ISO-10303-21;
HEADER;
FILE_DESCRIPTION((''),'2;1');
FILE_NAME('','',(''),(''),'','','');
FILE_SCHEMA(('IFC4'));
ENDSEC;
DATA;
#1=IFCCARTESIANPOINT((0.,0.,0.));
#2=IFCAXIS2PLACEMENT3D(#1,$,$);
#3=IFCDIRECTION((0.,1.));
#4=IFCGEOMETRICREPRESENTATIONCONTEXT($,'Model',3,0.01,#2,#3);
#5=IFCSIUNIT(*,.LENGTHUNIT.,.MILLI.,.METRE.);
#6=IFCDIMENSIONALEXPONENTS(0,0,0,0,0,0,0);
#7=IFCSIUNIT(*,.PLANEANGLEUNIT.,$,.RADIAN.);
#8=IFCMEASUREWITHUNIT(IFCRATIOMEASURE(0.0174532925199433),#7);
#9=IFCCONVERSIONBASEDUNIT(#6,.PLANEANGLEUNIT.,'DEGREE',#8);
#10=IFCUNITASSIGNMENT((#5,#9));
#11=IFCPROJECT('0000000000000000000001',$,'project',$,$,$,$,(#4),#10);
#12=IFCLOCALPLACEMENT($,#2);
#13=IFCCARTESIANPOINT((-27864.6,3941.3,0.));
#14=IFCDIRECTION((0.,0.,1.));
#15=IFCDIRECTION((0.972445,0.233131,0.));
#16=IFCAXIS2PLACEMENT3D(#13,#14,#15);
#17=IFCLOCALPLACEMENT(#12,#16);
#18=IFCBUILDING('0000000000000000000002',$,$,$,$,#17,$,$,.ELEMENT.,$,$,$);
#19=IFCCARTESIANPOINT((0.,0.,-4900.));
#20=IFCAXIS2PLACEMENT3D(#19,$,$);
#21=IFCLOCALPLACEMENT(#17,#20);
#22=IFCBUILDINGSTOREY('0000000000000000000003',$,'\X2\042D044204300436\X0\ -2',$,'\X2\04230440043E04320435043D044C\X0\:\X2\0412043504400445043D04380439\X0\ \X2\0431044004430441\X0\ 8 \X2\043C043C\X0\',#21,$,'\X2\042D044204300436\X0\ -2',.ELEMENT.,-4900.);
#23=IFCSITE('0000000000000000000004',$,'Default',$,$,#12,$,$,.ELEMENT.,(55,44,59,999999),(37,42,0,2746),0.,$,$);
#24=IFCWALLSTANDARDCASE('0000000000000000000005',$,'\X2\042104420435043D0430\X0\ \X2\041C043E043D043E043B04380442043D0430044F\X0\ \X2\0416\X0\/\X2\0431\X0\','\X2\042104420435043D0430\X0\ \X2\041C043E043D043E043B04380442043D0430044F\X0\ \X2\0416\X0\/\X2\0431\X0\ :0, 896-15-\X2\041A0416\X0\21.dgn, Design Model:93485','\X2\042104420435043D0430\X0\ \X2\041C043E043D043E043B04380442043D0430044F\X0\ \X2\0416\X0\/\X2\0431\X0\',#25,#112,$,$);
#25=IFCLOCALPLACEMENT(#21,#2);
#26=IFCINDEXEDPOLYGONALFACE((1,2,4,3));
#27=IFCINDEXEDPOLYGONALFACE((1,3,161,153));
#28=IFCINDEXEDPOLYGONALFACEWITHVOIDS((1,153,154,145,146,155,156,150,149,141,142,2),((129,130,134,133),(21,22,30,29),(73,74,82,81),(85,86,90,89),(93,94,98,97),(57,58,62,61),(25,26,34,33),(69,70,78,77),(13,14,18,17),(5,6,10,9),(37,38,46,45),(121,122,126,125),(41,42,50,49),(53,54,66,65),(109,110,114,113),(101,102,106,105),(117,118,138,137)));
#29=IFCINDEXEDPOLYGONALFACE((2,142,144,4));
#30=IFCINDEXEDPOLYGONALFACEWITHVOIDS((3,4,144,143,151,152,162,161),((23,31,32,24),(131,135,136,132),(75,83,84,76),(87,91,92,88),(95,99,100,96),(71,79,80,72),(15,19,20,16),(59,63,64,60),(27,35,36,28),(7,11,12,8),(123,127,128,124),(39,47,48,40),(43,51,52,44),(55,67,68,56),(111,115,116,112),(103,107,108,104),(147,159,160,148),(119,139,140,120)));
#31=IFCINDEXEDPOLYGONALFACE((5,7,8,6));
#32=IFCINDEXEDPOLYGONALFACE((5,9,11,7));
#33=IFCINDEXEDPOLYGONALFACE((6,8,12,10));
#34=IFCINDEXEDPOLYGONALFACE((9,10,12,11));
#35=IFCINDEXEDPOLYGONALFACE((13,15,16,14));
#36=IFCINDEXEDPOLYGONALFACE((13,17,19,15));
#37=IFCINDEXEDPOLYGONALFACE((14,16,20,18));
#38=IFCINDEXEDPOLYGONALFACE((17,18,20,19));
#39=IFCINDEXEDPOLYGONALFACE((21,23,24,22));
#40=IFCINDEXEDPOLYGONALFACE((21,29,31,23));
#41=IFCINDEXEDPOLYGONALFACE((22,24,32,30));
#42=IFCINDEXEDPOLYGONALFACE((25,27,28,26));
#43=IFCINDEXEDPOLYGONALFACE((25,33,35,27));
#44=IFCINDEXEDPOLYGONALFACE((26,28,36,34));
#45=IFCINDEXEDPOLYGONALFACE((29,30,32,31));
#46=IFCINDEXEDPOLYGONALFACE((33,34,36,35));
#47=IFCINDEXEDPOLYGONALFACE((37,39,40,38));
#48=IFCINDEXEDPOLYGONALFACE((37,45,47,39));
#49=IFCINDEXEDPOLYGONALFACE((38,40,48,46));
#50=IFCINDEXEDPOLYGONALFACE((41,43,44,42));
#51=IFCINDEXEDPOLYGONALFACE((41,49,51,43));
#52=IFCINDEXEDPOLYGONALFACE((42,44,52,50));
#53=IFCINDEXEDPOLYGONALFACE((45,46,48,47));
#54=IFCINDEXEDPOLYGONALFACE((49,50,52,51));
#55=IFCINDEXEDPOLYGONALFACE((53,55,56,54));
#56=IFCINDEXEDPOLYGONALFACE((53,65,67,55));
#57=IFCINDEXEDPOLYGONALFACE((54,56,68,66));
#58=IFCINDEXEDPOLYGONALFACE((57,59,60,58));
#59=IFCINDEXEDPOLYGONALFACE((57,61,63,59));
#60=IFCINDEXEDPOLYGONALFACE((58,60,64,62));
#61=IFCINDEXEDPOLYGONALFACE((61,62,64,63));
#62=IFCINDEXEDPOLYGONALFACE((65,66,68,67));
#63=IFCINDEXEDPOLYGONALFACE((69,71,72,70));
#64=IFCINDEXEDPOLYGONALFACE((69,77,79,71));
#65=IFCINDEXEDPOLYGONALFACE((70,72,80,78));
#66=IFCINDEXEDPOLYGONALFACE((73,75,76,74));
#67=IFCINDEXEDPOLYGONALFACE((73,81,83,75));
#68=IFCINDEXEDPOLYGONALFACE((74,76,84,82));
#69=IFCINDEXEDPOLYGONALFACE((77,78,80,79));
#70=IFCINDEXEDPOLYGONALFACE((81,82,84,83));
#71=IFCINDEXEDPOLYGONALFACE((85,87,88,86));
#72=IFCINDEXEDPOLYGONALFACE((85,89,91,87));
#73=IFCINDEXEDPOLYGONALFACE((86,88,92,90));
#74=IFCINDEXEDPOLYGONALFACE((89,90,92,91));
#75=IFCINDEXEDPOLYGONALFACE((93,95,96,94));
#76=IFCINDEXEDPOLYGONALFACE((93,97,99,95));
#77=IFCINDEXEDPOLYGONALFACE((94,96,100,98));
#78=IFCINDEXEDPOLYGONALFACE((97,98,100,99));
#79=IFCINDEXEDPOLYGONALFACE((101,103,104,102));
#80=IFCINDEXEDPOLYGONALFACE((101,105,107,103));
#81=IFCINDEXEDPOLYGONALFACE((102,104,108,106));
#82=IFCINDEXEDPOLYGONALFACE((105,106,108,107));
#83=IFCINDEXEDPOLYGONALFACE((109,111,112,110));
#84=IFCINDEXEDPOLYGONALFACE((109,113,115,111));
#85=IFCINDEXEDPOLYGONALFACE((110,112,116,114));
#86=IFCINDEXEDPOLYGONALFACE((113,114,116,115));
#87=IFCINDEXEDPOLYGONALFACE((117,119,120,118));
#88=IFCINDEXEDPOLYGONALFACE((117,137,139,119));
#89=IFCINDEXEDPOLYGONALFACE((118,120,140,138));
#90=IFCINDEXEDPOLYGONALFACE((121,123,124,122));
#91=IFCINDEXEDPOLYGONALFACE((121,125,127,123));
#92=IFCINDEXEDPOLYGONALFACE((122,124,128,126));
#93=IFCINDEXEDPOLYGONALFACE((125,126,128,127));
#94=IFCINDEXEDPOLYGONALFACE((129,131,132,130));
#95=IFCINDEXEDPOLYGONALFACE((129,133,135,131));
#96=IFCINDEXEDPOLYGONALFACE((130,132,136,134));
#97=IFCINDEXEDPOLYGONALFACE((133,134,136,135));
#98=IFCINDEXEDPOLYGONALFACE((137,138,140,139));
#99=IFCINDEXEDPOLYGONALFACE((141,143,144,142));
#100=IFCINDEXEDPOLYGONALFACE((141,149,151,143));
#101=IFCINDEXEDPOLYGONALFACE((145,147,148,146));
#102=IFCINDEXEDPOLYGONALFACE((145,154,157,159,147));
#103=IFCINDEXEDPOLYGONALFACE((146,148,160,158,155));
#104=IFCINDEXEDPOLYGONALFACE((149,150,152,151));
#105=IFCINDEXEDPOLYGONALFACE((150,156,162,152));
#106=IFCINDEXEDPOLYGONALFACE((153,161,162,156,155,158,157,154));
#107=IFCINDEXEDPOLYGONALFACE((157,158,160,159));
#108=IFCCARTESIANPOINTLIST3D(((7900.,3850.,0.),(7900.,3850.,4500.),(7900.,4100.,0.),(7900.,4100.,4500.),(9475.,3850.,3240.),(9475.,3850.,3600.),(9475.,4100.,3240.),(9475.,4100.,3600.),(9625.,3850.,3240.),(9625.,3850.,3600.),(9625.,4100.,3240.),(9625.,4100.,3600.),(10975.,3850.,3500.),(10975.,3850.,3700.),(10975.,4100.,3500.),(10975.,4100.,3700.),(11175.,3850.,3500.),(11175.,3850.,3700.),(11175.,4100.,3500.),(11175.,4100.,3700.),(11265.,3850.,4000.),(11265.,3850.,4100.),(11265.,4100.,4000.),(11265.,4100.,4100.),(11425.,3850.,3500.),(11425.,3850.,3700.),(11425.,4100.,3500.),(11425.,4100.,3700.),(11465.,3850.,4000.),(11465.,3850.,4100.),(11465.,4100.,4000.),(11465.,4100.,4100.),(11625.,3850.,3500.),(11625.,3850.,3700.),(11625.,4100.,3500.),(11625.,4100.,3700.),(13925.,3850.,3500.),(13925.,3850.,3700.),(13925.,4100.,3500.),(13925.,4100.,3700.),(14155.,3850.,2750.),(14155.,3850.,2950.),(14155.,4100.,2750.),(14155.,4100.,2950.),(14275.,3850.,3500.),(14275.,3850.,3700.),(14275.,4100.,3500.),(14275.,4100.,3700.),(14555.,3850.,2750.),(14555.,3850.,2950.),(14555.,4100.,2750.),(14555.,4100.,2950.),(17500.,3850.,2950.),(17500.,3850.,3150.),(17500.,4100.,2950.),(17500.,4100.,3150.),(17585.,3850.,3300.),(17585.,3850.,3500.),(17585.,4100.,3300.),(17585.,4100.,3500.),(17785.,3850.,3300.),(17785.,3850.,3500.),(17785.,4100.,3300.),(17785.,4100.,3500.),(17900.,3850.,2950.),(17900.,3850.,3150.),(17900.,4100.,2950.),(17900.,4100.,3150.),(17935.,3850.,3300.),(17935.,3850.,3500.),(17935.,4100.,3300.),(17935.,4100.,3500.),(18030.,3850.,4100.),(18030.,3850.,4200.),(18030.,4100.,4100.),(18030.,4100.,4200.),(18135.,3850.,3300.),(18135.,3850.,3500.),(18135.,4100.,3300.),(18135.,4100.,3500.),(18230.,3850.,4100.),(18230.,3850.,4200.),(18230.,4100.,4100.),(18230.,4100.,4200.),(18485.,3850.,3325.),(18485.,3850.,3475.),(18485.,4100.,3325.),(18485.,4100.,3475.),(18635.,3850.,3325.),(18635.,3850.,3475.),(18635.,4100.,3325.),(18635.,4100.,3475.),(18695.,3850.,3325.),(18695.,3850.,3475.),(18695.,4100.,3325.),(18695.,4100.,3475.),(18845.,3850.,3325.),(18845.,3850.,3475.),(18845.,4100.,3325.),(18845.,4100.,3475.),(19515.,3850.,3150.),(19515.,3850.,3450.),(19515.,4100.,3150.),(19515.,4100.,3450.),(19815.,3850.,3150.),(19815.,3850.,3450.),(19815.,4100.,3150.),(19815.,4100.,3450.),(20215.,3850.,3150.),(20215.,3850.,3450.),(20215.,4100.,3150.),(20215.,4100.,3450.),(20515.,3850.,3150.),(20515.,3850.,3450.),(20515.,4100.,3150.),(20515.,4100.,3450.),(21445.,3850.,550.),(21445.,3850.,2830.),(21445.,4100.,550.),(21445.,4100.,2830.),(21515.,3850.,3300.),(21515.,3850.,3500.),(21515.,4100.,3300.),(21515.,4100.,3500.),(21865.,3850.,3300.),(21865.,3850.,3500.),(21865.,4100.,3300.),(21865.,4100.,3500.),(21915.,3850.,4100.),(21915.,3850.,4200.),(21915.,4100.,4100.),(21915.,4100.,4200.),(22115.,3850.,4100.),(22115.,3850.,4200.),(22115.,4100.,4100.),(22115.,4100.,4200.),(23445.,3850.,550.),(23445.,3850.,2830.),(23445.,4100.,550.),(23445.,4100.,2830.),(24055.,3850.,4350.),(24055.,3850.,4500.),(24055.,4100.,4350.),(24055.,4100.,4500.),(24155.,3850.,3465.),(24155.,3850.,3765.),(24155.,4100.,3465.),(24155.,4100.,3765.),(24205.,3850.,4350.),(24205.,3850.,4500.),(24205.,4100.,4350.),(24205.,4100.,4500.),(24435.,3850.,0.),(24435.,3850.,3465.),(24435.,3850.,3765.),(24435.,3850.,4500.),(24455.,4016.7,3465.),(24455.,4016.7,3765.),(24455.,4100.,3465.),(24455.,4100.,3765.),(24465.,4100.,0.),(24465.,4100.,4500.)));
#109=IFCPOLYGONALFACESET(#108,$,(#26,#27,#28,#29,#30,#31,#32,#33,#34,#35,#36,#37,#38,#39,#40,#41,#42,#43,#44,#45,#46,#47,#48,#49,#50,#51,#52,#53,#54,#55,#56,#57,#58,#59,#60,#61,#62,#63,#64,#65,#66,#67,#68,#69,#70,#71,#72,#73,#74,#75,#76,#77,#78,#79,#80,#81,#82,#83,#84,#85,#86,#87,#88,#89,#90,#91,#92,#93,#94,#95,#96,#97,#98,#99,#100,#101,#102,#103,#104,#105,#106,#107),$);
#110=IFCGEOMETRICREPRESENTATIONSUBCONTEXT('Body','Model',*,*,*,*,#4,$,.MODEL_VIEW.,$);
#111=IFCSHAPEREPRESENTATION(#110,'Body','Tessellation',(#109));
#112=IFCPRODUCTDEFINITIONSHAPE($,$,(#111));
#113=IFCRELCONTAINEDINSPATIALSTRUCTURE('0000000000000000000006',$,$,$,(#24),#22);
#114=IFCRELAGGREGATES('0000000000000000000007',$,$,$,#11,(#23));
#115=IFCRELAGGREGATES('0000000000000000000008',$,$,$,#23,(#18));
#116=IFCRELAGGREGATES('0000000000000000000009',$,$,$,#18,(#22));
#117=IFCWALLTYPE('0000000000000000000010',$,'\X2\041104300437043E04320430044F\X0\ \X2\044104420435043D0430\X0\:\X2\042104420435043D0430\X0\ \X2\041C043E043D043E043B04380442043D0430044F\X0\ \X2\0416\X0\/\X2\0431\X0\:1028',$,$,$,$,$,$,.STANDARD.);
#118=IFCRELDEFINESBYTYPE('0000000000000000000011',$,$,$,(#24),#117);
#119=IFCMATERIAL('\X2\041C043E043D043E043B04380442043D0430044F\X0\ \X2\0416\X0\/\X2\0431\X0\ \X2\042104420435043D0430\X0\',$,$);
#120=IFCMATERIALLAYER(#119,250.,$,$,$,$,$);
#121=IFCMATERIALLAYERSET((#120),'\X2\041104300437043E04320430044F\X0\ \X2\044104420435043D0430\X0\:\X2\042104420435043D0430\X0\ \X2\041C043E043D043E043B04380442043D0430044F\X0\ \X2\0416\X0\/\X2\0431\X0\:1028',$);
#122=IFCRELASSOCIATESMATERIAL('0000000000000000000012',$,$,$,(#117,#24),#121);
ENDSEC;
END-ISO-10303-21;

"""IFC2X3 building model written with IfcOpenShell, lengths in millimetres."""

from ifc_helpers import new_model, entity, si_unit, converted_unit, direction, frame, origin, origin_2d_with_axis, place, context, subcontext, project, spatial, polyline, rectangle, outline, extrude, material, layer, layer_set, layer_usage, type_object, element, save


model = new_model("IFC2X3")

# Units and contexts
model_context = context("Model", 3, precision=0.01, world=origin(), true_north=direction((0.0, 1.0)))
body_context = subcontext(model_context, "Body", "Model", "MODEL_VIEW")
ifc_project = project(units=[si_unit("LENGTHUNIT", "METRE", prefix="MILLI"), converted_unit("PLANEANGLEUNIT", "DEGREE", entity("IfcRatioMeasure", 0.0174532925199433), si_unit("PLANEANGLEUNIT", "RADIAN"), dimensions=[0, 0, 0, 0, 0, 0, 0])], contexts=[model_context])

# Site, building, storey
site_placement = place(None, origin())
site = spatial("IfcSite", under=ifc_project, at=site_placement, Name="Default", CompositionType="ELEMENT", RefLatitude=(55, 44, 59, 999999), RefLongitude=(37, 42, 0, 2746), RefElevation=0.0)
building_placement = place(site_placement, frame((-27864.6, 3941.3, 0.0), z_axis=(0.0, 0.0, 1.0), x_axis=(0.972445, 0.233131, 0.0)))
building = spatial("IfcBuilding", under=site, at=building_placement, CompositionType="ELEMENT")
storey_placement = place(building_placement, frame((0.0, 0.0, -4900.0)))
storey = spatial("IfcBuildingStorey", under=building, at=storey_placement, Name="Этаж -2", ObjectType="Уровень:Верхний брус 8 мм", LongName="Этаж -2", CompositionType="ELEMENT", Elevation=-4900.0)

# Shared definitions
ifc_material = material(Name="Монолитная Ж/б Стена")

# Wall, openings
ifc_layer_1 = layer(ifc_material, 250.0)
ifc_layer_set_1 = layer_set([ifc_layer_1], Name="Базовая стена:Стена Монолитная Ж/б:1028")
ifc_layer_usage_1 = layer_usage(ifc_layer_set_1, "AXIS2", "NEGATIVE", 125.0)
wall_type_1 = type_object("IfcWallType", Name="Базовая стена:Стена Монолитная Ж/б:1028", PredefinedType="STANDARD", material=ifc_layer_set_1)
wall_1_placement = place(storey_placement, frame((24465.0, 3975.0, 0.0), z_axis=(0.0, 0.0, 1.0), x_axis=(-1.0, 0.0, 0.0)))
wall_1 = element("IfcWallStandardCase", 1, at=wall_1_placement, inside=storey, type_object=wall_type_1, material=ifc_layer_usage_1, Name="Стена Монолитная Ж/б", Description="Стена Монолитная Ж/б :0, 896-15-КЖ21.dgn, Design Model:93485", ObjectType="Стена Монолитная Ж/б", context=body_context, shape_type="SweptSolid", body=[
    extrude(outline(polyline([(16565.0, -125.0), (16565.0, 125.0), (30.0, 125.0), (0.0, -125.0), (16565.0, -125.0)])), origin(), (0.0, 0.0, 1.0), 4500.0),
])
opening_1_placement = place(wall_1_placement, origin())
element("IfcOpeningElement", 2, at=opening_1_placement, cuts=wall_1, ObjectType="Opening", context=body_context, shape_type="SweptSolid", body=[
    extrude(rectangle(XDim=2280.0, YDim=2000.0, at=origin_2d_with_axis()), frame((2020.0, -125.0, 1690.0), z_axis=(0.0, 1.0, 0.0), x_axis=(0.0, 0.0, -1.0)), (0.0, 0.0, 1.0), 250.0),
])
opening_2_placement = place(wall_1_placement, origin())
element("IfcOpeningElement", 3, at=opening_2_placement, cuts=wall_1, ObjectType="Opening", context=body_context, shape_type="SweptSolid", body=[
    extrude(rectangle(XDim=360.0, YDim=150.0, at=origin_2d_with_axis()), frame((14915.0, -125.0, 3420.0), z_axis=(0.0, 1.0, 0.0), x_axis=(0.0, 0.0, -1.0)), (0.0, 0.0, 1.0), 250.0),
])
opening_3_placement = place(wall_1_placement, origin())
element("IfcOpeningElement", 4, at=opening_3_placement, cuts=wall_1, ObjectType="Opening", context=body_context, shape_type="SweptSolid", body=[
    extrude(rectangle(XDim=200.0, YDim=200.0, at=origin_2d_with_axis()), frame((13390.0, -125.0, 3600.0), z_axis=(0.0, 1.0, 0.0), x_axis=(0.0, 0.0, -1.0)), (0.0, 0.0, 1.0), 250.0),
])
opening_4_placement = place(wall_1_placement, origin())
element("IfcOpeningElement", 5, at=opening_4_placement, cuts=wall_1, ObjectType="Opening", context=body_context, shape_type="SweptSolid", body=[
    extrude(rectangle(XDim=200.0, YDim=200.0, at=origin_2d_with_axis()), frame((12940.0, -125.0, 3600.0), z_axis=(0.0, 1.0, 0.0), x_axis=(0.0, 0.0, -1.0)), (0.0, 0.0, 1.0), 250.0),
])
opening_5_placement = place(wall_1_placement, origin())
element("IfcOpeningElement", 6, at=opening_5_placement, cuts=wall_1, ObjectType="Opening", context=body_context, shape_type="SweptSolid", body=[
    extrude(rectangle(XDim=200.0, YDim=350.0, at=origin_2d_with_axis()), frame((10365.0, -125.0, 3600.0), z_axis=(0.0, 1.0, 0.0), x_axis=(0.0, 0.0, -1.0)), (0.0, 0.0, 1.0), 250.0),
])
opening_6_placement = place(wall_1_placement, origin())
element("IfcOpeningElement", 7, at=opening_6_placement, cuts=wall_1, ObjectType="Opening", context=body_context, shape_type="SweptSolid", body=[
    extrude(rectangle(XDim=100.0, YDim=200.0, at=origin_2d_with_axis()), frame((13100.0, -125.0, 4050.0), z_axis=(0.0, 1.0, 0.0), x_axis=(0.0, 0.0, -1.0)), (0.0, 0.0, 1.0), 250.0),
])
opening_7_placement = place(wall_1_placement, origin())
element("IfcOpeningElement", 8, at=opening_7_placement, cuts=wall_1, ObjectType="Opening", context=body_context, shape_type="SweptSolid", body=[
    extrude(rectangle(XDim=200.0, YDim=400.0, at=origin_2d_with_axis()), frame((10110.0, -125.0, 2850.0), z_axis=(0.0, 1.0, 0.0), x_axis=(0.0, 0.0, -1.0)), (0.0, 0.0, 1.0), 250.0),
])
opening_8_placement = place(wall_1_placement, origin())
element("IfcOpeningElement", 9, at=opening_8_placement, cuts=wall_1, ObjectType="Opening", context=body_context, shape_type="SweptSolid", body=[
    extrude(rectangle(XDim=200.0, YDim=200.0, at=origin_2d_with_axis()), frame((6780.0, -125.0, 3400.0), z_axis=(0.0, 1.0, 0.0), x_axis=(0.0, 0.0, -1.0)), (0.0, 0.0, 1.0), 250.0),
])
opening_9_placement = place(wall_1_placement, origin())
element("IfcOpeningElement", 10, at=opening_9_placement, cuts=wall_1, ObjectType="Opening", context=body_context, shape_type="SweptSolid", body=[
    extrude(rectangle(XDim=200.0, YDim=200.0, at=origin_2d_with_axis()), frame((6430.0, -125.0, 3400.0), z_axis=(0.0, 1.0, 0.0), x_axis=(0.0, 0.0, -1.0)), (0.0, 0.0, 1.0), 250.0),
])
opening_10_placement = place(wall_1_placement, origin())
element("IfcOpeningElement", 11, at=opening_10_placement, cuts=wall_1, ObjectType="Opening", context=body_context, shape_type="SweptSolid", body=[
    extrude(rectangle(XDim=150.0, YDim=150.0, at=origin_2d_with_axis()), frame((5905.0, -125.0, 3400.0), z_axis=(0.0, 1.0, 0.0), x_axis=(0.0, 0.0, -1.0)), (0.0, 0.0, 1.0), 250.0),
])
opening_11_placement = place(wall_1_placement, origin())
element("IfcOpeningElement", 12, at=opening_11_placement, cuts=wall_1, ObjectType="Opening", context=body_context, shape_type="SweptSolid", body=[
    extrude(rectangle(XDim=150.0, YDim=150.0, at=origin_2d_with_axis()), frame((5695.0, -125.0, 3400.0), z_axis=(0.0, 1.0, 0.0), x_axis=(0.0, 0.0, -1.0)), (0.0, 0.0, 1.0), 250.0),
])
opening_12_placement = place(wall_1_placement, origin())
element("IfcOpeningElement", 13, at=opening_12_placement, cuts=wall_1, ObjectType="Opening", context=body_context, shape_type="SweptSolid", body=[
    extrude(rectangle(XDim=300.0, YDim=300.0, at=origin_2d_with_axis()), frame((4800.0, -125.0, 3300.0), z_axis=(0.0, 1.0, 0.0), x_axis=(0.0, 0.0, -1.0)), (0.0, 0.0, 1.0), 250.0),
])
opening_13_placement = place(wall_1_placement, origin())
element("IfcOpeningElement", 14, at=opening_13_placement, cuts=wall_1, ObjectType="Opening", context=body_context, shape_type="SweptSolid", body=[
    extrude(rectangle(XDim=300.0, YDim=300.0, at=origin_2d_with_axis()), frame((4100.0, -125.0, 3300.0), z_axis=(0.0, 1.0, 0.0), x_axis=(0.0, 0.0, -1.0)), (0.0, 0.0, 1.0), 250.0),
])
opening_14_placement = place(wall_1_placement, origin())
element("IfcOpeningElement", 15, at=opening_14_placement, cuts=wall_1, ObjectType="Opening", context=body_context, shape_type="SweptSolid", body=[
    extrude(rectangle(XDim=200.0, YDim=350.0, at=origin_2d_with_axis()), frame((2775.0, -125.0, 3400.0), z_axis=(0.0, 1.0, 0.0), x_axis=(0.0, 0.0, -1.0)), (0.0, 0.0, 1.0), 250.0),
])
opening_15_placement = place(wall_1_placement, origin())
element("IfcOpeningElement", 16, at=opening_15_placement, cuts=wall_1, ObjectType="Opening", context=body_context, shape_type="SweptSolid", body=[
    extrude(rectangle(XDim=300.0, YDim=300.0, at=origin_2d_with_axis()), frame((160.0, -125.0, 3615.0), z_axis=(0.0, 1.0, 0.0), x_axis=(0.0, 0.0, -1.0)), (0.0, 0.0, 1.0), 250.0),
])
opening_16_placement = place(wall_1_placement, origin())
element("IfcOpeningElement", 17, at=opening_16_placement, cuts=wall_1, ObjectType="Opening", context=body_context, shape_type="SweptSolid", body=[
    extrude(rectangle(XDim=200.0, YDim=400.0, at=origin_2d_with_axis()), frame((6765.0, -125.0, 3050.0), z_axis=(0.0, 1.0, 0.0), x_axis=(0.0, 0.0, -1.0)), (0.0, 0.0, 1.0), 250.0),
])
opening_17_placement = place(wall_1_placement, origin())
element("IfcOpeningElement", 18, at=opening_17_placement, cuts=wall_1, ObjectType="Opening", context=body_context, shape_type="SweptSolid", body=[
    extrude(rectangle(XDim=100.0, YDim=200.0, at=origin_2d_with_axis()), frame((6335.0, -125.0, 4150.0), z_axis=(0.0, 1.0, 0.0), x_axis=(0.0, 0.0, -1.0)), (0.0, 0.0, 1.0), 250.0),
])
opening_18_placement = place(wall_1_placement, origin())
element("IfcOpeningElement", 19, at=opening_18_placement, cuts=wall_1, ObjectType="Opening", context=body_context, shape_type="SweptSolid", body=[
    extrude(rectangle(XDim=100.0, YDim=200.0, at=origin_2d_with_axis()), frame((2450.0, -125.0, 4150.0), z_axis=(0.0, 1.0, 0.0), x_axis=(0.0, 0.0, -1.0)), (0.0, 0.0, 1.0), 250.0),
])
opening_19_placement = place(wall_1_placement, origin())
element("IfcOpeningElement", 20, at=opening_19_placement, cuts=wall_1, ObjectType="Opening", context=body_context, shape_type="SweptSolid", body=[
    extrude(rectangle(XDim=150.0, YDim=150.0, at=origin_2d_with_axis()), frame((335.0, -125.0, 4425.0), z_axis=(0.0, 1.0, 0.0), x_axis=(0.0, 0.0, -1.0)), (0.0, 0.0, 1.0), 250.0),
])

save(model, "model.ifc")
